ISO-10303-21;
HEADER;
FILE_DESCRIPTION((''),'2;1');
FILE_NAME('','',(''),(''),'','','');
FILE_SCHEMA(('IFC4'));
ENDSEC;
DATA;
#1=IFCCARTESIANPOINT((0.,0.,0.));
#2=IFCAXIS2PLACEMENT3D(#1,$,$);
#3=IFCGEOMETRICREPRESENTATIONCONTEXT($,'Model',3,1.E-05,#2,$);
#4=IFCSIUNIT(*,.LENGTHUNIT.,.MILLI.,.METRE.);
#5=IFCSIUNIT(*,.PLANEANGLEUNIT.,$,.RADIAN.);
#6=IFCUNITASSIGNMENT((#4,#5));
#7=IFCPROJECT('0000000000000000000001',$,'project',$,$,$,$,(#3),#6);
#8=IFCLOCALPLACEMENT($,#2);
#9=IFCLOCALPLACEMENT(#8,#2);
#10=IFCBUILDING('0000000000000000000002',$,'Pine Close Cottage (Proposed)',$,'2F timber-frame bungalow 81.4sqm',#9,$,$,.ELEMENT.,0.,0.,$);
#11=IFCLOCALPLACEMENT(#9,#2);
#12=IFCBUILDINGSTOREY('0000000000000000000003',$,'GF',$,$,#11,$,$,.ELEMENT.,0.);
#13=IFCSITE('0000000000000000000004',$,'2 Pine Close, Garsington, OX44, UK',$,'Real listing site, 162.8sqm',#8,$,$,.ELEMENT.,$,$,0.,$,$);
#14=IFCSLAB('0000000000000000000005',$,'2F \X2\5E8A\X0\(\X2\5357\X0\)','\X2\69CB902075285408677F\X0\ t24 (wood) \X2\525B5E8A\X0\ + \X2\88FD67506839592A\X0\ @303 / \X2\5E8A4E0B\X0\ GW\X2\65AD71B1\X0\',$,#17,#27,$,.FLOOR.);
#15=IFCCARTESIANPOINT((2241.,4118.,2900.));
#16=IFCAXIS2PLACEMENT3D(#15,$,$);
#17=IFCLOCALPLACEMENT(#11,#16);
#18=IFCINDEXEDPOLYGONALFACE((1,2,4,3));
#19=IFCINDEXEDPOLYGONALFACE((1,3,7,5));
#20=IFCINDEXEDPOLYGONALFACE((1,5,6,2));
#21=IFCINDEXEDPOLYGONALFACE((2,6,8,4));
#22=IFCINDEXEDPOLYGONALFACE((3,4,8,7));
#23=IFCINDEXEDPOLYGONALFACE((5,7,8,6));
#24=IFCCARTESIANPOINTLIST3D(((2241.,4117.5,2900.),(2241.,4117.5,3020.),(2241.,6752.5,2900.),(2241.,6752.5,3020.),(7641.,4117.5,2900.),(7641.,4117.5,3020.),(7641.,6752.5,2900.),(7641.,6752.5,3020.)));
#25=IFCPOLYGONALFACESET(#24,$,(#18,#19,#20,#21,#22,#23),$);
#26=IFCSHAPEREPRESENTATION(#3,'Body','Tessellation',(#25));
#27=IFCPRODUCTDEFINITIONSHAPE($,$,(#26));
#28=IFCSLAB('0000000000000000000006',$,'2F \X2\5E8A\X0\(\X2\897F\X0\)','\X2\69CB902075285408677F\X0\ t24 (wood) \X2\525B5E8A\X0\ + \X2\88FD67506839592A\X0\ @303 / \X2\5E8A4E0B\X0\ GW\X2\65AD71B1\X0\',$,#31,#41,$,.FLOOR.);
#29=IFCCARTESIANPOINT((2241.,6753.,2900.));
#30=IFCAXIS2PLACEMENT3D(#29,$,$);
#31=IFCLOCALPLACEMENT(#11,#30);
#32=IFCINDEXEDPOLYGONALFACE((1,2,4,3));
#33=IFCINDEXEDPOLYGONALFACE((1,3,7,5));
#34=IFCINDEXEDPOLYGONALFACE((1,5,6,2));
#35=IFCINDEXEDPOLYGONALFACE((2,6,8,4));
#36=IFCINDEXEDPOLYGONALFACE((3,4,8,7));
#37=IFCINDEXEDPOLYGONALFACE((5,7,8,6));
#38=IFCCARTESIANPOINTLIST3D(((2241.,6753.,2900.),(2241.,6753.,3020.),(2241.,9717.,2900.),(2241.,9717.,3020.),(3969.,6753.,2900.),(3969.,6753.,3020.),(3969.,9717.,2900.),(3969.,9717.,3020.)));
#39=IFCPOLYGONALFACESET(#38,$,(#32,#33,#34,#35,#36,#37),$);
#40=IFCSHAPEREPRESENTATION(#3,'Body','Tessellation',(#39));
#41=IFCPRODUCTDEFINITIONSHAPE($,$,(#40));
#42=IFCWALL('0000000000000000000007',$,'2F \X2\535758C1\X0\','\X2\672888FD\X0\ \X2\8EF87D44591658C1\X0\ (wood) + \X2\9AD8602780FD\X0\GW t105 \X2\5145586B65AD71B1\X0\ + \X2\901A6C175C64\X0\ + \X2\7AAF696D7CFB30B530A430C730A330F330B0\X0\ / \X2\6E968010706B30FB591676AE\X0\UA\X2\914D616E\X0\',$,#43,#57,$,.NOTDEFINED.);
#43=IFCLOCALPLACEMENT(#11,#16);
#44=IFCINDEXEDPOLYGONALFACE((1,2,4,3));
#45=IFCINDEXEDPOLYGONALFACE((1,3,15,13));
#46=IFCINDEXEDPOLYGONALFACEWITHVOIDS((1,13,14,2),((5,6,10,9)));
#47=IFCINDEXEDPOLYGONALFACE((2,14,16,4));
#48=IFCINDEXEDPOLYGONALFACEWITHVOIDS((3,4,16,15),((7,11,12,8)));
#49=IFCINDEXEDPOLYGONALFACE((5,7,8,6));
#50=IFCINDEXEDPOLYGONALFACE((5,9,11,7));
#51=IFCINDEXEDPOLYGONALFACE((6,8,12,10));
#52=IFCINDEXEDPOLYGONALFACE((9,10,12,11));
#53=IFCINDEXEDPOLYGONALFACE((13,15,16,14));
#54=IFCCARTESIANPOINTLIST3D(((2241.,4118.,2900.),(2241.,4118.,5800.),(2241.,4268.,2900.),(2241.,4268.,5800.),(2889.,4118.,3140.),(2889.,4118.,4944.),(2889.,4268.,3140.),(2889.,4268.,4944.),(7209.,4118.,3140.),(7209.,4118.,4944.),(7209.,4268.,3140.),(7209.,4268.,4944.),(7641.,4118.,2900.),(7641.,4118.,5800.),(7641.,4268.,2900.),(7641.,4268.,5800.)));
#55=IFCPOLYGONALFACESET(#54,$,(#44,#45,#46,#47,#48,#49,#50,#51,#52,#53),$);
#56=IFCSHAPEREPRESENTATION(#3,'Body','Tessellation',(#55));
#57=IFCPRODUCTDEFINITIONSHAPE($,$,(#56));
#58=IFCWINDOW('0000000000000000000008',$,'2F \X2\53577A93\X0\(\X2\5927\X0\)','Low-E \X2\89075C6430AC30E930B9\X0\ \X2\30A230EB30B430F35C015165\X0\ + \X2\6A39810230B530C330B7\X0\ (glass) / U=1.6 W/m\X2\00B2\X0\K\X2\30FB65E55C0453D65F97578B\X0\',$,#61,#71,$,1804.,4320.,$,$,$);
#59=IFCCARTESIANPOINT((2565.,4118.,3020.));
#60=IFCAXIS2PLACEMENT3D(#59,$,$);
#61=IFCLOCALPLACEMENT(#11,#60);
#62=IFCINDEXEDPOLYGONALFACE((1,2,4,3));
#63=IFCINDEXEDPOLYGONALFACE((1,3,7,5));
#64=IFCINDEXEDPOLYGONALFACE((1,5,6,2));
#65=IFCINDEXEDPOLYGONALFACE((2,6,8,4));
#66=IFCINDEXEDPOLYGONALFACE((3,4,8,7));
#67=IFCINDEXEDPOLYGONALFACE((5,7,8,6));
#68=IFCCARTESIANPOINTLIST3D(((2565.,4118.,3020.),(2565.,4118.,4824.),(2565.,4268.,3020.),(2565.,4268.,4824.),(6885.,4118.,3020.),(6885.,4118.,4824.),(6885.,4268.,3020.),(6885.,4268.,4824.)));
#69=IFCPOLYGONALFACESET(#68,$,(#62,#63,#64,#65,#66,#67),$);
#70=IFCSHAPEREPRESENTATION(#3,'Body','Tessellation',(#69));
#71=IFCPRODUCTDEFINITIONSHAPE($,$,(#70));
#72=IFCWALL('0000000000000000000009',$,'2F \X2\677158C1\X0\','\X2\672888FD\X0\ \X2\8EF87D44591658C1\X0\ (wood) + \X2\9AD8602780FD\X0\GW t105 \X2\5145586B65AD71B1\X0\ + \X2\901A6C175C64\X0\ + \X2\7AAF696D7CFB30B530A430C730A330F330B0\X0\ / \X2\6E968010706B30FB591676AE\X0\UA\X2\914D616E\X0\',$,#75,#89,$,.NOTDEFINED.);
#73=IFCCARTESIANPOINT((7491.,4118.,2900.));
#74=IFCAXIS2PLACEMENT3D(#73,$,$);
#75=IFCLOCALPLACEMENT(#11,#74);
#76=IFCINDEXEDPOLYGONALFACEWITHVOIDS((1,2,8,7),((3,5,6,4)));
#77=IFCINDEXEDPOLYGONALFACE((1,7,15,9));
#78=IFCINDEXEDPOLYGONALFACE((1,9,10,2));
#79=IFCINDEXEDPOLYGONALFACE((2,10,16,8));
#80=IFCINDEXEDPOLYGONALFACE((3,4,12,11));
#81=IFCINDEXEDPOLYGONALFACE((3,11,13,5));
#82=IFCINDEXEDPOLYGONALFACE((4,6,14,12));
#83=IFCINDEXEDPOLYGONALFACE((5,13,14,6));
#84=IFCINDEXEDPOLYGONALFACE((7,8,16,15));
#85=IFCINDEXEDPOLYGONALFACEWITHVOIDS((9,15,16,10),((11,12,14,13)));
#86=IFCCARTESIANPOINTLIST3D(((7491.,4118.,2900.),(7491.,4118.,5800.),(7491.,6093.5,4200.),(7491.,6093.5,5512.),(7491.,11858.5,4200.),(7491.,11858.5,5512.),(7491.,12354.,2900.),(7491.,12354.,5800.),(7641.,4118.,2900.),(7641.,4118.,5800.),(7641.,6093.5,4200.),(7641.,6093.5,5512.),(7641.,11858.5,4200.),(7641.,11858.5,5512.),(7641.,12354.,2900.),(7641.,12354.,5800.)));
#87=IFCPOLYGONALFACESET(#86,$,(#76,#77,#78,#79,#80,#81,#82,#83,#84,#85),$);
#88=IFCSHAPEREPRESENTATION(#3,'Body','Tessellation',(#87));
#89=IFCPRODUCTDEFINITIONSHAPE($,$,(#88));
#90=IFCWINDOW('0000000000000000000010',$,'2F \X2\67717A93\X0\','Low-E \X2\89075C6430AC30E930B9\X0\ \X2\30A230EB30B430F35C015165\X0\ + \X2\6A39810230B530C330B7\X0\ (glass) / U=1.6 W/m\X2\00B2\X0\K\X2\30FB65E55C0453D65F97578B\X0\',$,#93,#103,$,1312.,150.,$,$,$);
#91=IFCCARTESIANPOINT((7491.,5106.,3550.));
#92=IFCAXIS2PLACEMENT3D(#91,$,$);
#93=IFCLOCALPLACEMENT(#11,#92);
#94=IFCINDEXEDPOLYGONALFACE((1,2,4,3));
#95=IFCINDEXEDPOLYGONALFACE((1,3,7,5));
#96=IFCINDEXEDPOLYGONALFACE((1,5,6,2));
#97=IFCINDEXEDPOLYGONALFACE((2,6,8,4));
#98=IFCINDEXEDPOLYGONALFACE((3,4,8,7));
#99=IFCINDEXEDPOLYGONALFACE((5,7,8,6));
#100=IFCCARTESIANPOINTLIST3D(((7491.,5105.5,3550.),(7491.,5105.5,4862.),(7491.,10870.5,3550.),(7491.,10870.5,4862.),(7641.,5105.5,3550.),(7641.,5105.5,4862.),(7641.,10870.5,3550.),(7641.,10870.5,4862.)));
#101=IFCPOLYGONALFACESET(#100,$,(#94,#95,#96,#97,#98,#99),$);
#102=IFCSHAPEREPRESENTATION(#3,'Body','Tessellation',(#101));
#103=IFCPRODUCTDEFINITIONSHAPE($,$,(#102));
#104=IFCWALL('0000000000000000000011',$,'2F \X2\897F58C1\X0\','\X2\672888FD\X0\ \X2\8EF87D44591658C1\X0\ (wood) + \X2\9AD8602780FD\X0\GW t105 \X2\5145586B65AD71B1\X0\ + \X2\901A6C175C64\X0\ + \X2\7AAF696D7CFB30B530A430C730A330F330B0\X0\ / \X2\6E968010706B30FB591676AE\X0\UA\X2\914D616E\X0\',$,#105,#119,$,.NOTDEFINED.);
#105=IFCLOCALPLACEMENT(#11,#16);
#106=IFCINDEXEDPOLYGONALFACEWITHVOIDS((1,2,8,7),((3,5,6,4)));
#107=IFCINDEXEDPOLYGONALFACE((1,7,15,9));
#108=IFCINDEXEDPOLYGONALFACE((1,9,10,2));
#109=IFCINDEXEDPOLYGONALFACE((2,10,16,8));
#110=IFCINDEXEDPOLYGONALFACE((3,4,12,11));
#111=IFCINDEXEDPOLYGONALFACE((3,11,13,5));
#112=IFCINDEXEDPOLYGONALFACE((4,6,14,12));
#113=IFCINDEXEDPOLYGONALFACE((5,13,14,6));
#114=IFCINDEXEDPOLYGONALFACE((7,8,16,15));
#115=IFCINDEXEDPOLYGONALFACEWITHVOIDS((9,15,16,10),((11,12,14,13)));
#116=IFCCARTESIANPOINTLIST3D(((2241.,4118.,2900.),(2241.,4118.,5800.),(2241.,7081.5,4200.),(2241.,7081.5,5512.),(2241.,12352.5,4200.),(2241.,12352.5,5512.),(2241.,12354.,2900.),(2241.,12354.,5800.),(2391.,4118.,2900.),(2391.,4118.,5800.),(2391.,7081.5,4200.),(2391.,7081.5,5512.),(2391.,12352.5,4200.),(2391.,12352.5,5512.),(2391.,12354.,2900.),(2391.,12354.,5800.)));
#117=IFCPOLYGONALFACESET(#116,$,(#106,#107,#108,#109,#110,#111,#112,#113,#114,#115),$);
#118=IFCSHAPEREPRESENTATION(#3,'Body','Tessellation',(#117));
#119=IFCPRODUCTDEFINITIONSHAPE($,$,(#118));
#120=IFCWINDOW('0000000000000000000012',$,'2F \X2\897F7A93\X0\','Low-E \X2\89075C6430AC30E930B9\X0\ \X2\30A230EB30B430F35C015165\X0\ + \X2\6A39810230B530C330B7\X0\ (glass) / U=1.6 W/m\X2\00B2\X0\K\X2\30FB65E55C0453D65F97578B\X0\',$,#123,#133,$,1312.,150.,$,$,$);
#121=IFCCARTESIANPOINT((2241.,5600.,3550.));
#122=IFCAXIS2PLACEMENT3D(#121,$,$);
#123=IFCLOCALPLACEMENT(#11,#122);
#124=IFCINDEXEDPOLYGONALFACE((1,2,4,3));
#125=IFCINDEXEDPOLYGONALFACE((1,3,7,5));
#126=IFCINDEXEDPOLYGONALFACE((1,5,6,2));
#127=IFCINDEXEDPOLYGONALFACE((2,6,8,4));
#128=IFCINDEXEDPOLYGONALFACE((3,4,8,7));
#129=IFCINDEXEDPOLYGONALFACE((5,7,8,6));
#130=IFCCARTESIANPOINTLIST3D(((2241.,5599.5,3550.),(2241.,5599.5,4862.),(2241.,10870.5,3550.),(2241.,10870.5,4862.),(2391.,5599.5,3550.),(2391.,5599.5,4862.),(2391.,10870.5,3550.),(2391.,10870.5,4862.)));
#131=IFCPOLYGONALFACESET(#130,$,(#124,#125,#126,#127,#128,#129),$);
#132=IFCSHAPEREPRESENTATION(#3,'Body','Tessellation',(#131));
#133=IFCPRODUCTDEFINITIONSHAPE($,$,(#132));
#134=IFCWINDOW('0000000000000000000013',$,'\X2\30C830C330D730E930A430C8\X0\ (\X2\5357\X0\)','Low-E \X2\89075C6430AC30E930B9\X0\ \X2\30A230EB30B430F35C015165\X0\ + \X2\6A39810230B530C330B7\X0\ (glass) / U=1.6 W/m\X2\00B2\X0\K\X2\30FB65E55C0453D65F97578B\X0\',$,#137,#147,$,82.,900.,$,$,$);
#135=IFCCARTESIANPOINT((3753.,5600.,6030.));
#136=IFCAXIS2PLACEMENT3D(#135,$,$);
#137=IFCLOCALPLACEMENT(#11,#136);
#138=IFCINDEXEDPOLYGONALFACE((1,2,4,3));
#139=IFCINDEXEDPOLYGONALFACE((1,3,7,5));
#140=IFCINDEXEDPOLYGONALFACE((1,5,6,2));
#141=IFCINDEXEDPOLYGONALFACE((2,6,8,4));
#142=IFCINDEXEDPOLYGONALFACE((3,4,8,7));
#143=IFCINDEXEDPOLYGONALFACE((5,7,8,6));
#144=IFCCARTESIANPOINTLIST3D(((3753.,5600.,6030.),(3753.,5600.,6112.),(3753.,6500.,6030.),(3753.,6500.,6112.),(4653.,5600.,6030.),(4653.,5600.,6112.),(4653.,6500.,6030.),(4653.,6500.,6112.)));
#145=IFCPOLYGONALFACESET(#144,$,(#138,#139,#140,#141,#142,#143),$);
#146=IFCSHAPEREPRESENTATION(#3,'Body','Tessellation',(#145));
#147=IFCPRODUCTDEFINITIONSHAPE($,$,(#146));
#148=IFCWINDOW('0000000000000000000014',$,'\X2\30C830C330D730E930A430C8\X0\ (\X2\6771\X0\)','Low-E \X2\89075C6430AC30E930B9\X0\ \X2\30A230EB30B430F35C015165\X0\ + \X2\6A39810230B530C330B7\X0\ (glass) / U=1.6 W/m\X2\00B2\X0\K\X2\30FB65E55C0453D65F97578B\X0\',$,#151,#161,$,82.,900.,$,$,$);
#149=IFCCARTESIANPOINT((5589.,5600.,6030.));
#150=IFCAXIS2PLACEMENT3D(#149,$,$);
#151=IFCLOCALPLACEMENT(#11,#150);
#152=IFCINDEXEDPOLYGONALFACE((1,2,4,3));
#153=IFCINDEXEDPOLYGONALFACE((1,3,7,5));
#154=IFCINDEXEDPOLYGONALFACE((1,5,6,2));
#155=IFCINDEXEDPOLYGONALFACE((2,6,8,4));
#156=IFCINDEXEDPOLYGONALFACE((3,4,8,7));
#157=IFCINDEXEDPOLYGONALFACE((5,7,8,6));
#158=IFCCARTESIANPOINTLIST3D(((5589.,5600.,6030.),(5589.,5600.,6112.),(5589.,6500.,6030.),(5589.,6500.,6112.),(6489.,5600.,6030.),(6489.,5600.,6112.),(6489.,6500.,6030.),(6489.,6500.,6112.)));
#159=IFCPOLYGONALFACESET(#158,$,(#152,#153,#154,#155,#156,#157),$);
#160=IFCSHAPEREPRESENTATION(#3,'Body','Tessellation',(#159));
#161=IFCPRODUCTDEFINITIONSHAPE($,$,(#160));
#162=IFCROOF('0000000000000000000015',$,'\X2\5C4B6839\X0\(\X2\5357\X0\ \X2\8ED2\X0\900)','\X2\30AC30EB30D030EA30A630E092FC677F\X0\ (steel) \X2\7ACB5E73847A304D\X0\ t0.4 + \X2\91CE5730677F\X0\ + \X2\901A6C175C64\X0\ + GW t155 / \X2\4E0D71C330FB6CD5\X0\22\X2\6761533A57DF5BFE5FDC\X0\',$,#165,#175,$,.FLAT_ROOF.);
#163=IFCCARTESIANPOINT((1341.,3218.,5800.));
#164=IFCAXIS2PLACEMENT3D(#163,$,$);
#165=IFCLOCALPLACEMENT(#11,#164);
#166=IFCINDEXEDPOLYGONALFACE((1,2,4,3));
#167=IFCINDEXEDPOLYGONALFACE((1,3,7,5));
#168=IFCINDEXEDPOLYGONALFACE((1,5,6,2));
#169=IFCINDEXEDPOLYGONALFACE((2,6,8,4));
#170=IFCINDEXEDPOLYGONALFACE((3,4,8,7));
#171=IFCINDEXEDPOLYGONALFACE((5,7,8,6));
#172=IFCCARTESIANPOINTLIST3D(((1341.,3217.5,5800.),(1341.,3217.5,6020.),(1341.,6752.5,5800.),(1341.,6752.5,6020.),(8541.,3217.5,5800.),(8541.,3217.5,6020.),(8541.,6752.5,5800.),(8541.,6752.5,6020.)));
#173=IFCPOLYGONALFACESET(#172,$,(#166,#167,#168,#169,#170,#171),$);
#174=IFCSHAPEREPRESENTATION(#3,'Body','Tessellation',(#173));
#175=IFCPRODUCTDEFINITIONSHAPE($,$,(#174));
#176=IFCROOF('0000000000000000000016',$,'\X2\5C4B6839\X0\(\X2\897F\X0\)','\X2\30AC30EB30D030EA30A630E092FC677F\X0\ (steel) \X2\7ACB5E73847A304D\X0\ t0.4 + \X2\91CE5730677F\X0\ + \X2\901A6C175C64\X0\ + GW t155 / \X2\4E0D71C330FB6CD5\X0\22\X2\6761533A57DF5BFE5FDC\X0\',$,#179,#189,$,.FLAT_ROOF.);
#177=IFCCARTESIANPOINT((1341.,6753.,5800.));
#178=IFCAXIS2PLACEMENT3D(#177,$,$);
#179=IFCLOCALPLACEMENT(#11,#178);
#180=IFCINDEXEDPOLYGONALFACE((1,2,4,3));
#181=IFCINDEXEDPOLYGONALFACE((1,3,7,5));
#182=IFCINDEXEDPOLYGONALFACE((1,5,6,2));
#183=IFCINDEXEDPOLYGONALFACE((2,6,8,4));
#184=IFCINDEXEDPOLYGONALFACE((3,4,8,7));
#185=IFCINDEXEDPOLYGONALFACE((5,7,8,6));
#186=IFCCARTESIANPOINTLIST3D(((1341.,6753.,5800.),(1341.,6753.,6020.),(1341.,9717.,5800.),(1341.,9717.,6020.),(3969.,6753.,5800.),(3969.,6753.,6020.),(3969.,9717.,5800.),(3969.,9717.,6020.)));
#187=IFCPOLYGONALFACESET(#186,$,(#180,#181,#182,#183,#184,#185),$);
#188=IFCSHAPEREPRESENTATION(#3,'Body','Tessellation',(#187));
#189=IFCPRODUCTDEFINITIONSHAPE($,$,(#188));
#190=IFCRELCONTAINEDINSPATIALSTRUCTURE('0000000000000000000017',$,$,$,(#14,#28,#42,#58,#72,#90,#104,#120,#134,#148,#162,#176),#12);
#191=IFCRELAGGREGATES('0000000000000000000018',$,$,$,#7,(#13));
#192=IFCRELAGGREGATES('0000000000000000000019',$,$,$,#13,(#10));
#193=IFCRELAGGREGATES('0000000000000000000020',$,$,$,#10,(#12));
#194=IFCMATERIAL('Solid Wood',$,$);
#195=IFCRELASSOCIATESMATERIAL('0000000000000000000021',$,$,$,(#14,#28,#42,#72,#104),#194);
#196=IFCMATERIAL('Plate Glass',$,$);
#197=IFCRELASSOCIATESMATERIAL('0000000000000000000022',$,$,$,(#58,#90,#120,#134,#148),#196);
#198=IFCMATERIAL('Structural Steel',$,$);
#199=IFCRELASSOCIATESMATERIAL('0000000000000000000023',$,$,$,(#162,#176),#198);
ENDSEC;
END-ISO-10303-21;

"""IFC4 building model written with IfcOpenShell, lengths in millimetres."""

from ifc_helpers import new_model, si_unit, frame, frame_2d, origin, place, context, project, spatial, rectangle, extrude, material, element, fill, save


model = new_model("IFC4")

# Units and contexts
model_context = context("Model", 3, precision=1e-05, world=origin())
ifc_project = project(units=[si_unit("LENGTHUNIT", "METRE", prefix="MILLI"), si_unit("PLANEANGLEUNIT", "RADIAN")], contexts=[model_context])

# Site, building, storey
site_placement = place(None, origin())
site = spatial("IfcSite", under=ifc_project, at=site_placement, Name="2 Pine Close, Garsington, OX44, UK", ObjectType="Real listing site, 162.8sqm", CompositionType="ELEMENT", RefElevation=0.0)
building_placement = place(site_placement, origin())
building = spatial("IfcBuilding", under=site, at=building_placement, Name="Pine Close Cottage (Proposed)", ObjectType="2F timber-frame bungalow 81.4sqm", CompositionType="ELEMENT", ElevationOfRefHeight=0.0, ElevationOfTerrain=0.0)
storey_placement = place(building_placement, origin())
storey = spatial("IfcBuildingStorey", under=building, at=storey_placement, Name="GF", CompositionType="ELEMENT", Elevation=0.0)

# Slabs
ifc_material_1 = material(Name="Solid Wood")
slab_1_placement = place(storey_placement, frame((2241.0, 4118.0, 2900.0)))
element("IfcSlab", 1, at=slab_1_placement, inside=storey, material=ifc_material_1, Name="2F 床(南)", Description="構造用合板 t24 (wood) 剛床 + 製材根太 @303 / 床下 GW断熱", PredefinedType="FLOOR", context=model_context, shape_type="SweptSolid", body=[
    extrude(rectangle(XDim=5400.0, YDim=2635.0, at=frame_2d((2700.0, 1317.0))), frame((2241.0, 4118.0, 2900.0)), (0.0, 0.0, 1.0), 120.0),
])
slab_2_placement = place(storey_placement, frame((2241.0, 6753.0, 2900.0)))
element("IfcSlab", 2, at=slab_2_placement, inside=storey, material=ifc_material_1, Name="2F 床(西)", Description="構造用合板 t24 (wood) 剛床 + 製材根太 @303 / 床下 GW断熱", PredefinedType="FLOOR", context=model_context, shape_type="SweptSolid", body=[
    extrude(rectangle(XDim=1728.0, YDim=2964.0, at=frame_2d((864.0, 1482.0))), frame((2241.0, 6753.0, 2900.0)), (0.0, 0.0, 1.0), 120.0),
])

# Walls, openings, windows
wall_1_placement = place(storey_placement, frame((2241.0, 4118.0, 2900.0)))
wall_1 = element("IfcWall", 3, at=wall_1_placement, inside=storey, material=ifc_material_1, Name="2F 南壁", Description="木製 軸組外壁 (wood) + 高性能GW t105 充填断熱 + 通気層 + 窯業系サイディング / 準耐火・外皮UA配慮", PredefinedType="NOTDEFINED", context=model_context, shape_type="SweptSolid", body=[
    extrude(rectangle(XDim=5400.0, YDim=150.0, at=frame_2d((2700.0, 75.0))), frame((2241.0, 4118.0, 2900.0)), (0.0, 0.0, 1.0), 2900.0),
])
opening_1_placement = place(storey_placement, frame((2565.0, 4118.0, 3020.0)))
opening_1 = element("IfcOpeningElement", 4, at=opening_1_placement, cuts=wall_1, PredefinedType="NOTDEFINED", context=model_context, shape_type="SweptSolid", body=[
    extrude(rectangle(XDim=4320.0, YDim=150.0, at=frame_2d((2160.0, 75.0))), frame((2565.0, 4118.0, 3020.0)), (0.0, 0.0, 1.0), 1804.0),
])
ifc_material_2 = material(Name="Plate Glass")
window_1_placement = place(storey_placement, frame((2565.0, 4118.0, 3020.0)))
window_1 = element("IfcWindow", 5, at=window_1_placement, inside=storey, material=ifc_material_2, Name="2F 南窓(大)", Description="Low-E 複層ガラス アルゴン封入 + 樹脂サッシ (glass) / U=1.6 W/m²K・日射取得型", OverallHeight=1804.0, OverallWidth=4320.0, context=model_context, shape_type="SweptSolid", body=[
    extrude(rectangle(XDim=4320.0, YDim=150.0, at=frame_2d((2160.0, 75.0))), frame((2565.0, 4118.0, 3020.0)), (0.0, 0.0, 1.0), 1804.0),
])
fill(opening_1, window_1)
wall_2_placement = place(storey_placement, frame((7491.0, 4118.0, 2900.0)))
wall_2 = element("IfcWall", 6, at=wall_2_placement, inside=storey, material=ifc_material_1, Name="2F 東壁", Description="木製 軸組外壁 (wood) + 高性能GW t105 充填断熱 + 通気層 + 窯業系サイディング / 準耐火・外皮UA配慮", PredefinedType="NOTDEFINED", context=model_context, shape_type="SweptSolid", body=[
    extrude(rectangle(XDim=150.0, YDim=8236.0, at=frame_2d((75.0, 4118.0))), frame((7491.0, 4118.0, 2900.0)), (0.0, 0.0, 1.0), 2900.0),
])
opening_2_placement = place(storey_placement, frame((7491.0, 5106.0, 3550.0)))
opening_2 = element("IfcOpeningElement", 7, at=opening_2_placement, cuts=wall_2, PredefinedType="NOTDEFINED", context=model_context, shape_type="SweptSolid", body=[
    extrude(rectangle(XDim=150.0, YDim=5765.0, at=frame_2d((75.0, 2882.0))), frame((7491.0, 5106.0, 3550.0)), (0.0, 0.0, 1.0), 1312.0),
])
window_2_placement = place(storey_placement, frame((7491.0, 5106.0, 3550.0)))
window_2 = element("IfcWindow", 8, at=window_2_placement, inside=storey, material=ifc_material_2, Name="2F 東窓", Description="Low-E 複層ガラス アルゴン封入 + 樹脂サッシ (glass) / U=1.6 W/m²K・日射取得型", OverallHeight=1312.0, OverallWidth=150.0, context=model_context, shape_type="SweptSolid", body=[
    extrude(rectangle(XDim=150.0, YDim=5765.0, at=frame_2d((75.0, 2882.0))), frame((7491.0, 5106.0, 3550.0)), (0.0, 0.0, 1.0), 1312.0),
])
fill(opening_2, window_2)
wall_3_placement = place(storey_placement, frame((2241.0, 4118.0, 2900.0)))
wall_3 = element("IfcWall", 9, at=wall_3_placement, inside=storey, material=ifc_material_1, Name="2F 西壁", Description="木製 軸組外壁 (wood) + 高性能GW t105 充填断熱 + 通気層 + 窯業系サイディング / 準耐火・外皮UA配慮", PredefinedType="NOTDEFINED", context=model_context, shape_type="SweptSolid", body=[
    extrude(rectangle(XDim=150.0, YDim=8236.0, at=frame_2d((75.0, 4118.0))), frame((2241.0, 4118.0, 2900.0)), (0.0, 0.0, 1.0), 2900.0),
])
opening_3_placement = place(storey_placement, frame((2241.0, 5600.0, 3550.0)))
opening_3 = element("IfcOpeningElement", 10, at=opening_3_placement, cuts=wall_3, PredefinedType="NOTDEFINED", context=model_context, shape_type="SweptSolid", body=[
    extrude(rectangle(XDim=150.0, YDim=5271.0, at=frame_2d((75.0, 2635.0))), frame((2241.0, 5600.0, 3550.0)), (0.0, 0.0, 1.0), 1312.0),
])
window_3_placement = place(storey_placement, frame((2241.0, 5600.0, 3550.0)))
window_3 = element("IfcWindow", 11, at=window_3_placement, inside=storey, material=ifc_material_2, Name="2F 西窓", Description="Low-E 複層ガラス アルゴン封入 + 樹脂サッシ (glass) / U=1.6 W/m²K・日射取得型", OverallHeight=1312.0, OverallWidth=150.0, context=model_context, shape_type="SweptSolid", body=[
    extrude(rectangle(XDim=150.0, YDim=5271.0, at=frame_2d((75.0, 2635.0))), frame((2241.0, 5600.0, 3550.0)), (0.0, 0.0, 1.0), 1312.0),
])
fill(opening_3, window_3)

# Windows
window_4_placement = place(storey_placement, frame((3753.0, 5600.0, 6030.0)))
element("IfcWindow", 12, at=window_4_placement, inside=storey, material=ifc_material_2, Name="トップライト (南)", Description="Low-E 複層ガラス アルゴン封入 + 樹脂サッシ (glass) / U=1.6 W/m²K・日射取得型", OverallHeight=82.0, OverallWidth=900.0, context=model_context, shape_type="SweptSolid", body=[
    extrude(rectangle(XDim=900.0, YDim=900.0, at=frame_2d((450.0, 450.0))), frame((3753.0, 5600.0, 6030.0)), (0.0, 0.0, 1.0), 82.0),
])
window_5_placement = place(storey_placement, frame((5589.0, 5600.0, 6030.0)))
element("IfcWindow", 13, at=window_5_placement, inside=storey, material=ifc_material_2, Name="トップライト (東)", Description="Low-E 複層ガラス アルゴン封入 + 樹脂サッシ (glass) / U=1.6 W/m²K・日射取得型", OverallHeight=82.0, OverallWidth=900.0, context=model_context, shape_type="SweptSolid", body=[
    extrude(rectangle(XDim=900.0, YDim=900.0, at=frame_2d((450.0, 450.0))), frame((5589.0, 5600.0, 6030.0)), (0.0, 0.0, 1.0), 82.0),
])

# Roofs
ifc_material_3 = material(Name="Structural Steel")
roof_1_placement = place(storey_placement, frame((1341.0, 3218.0, 5800.0)))
element("IfcRoof", 14, at=roof_1_placement, inside=storey, material=ifc_material_3, Name="屋根(南 軒900)", Description="ガルバリウム鋼板 (steel) 立平葺き t0.4 + 野地板 + 通気層 + GW t155 / 不燃・法22条区域対応", PredefinedType="FLAT_ROOF", context=model_context, shape_type="SweptSolid", body=[
    extrude(rectangle(XDim=7200.0, YDim=3535.0, at=frame_2d((3600.0, 1767.0))), frame((1341.0, 3218.0, 5800.0)), (0.0, 0.0, 1.0), 220.0),
])
roof_2_placement = place(storey_placement, frame((1341.0, 6753.0, 5800.0)))
element("IfcRoof", 15, at=roof_2_placement, inside=storey, material=ifc_material_3, Name="屋根(西)", Description="ガルバリウム鋼板 (steel) 立平葺き t0.4 + 野地板 + 通気層 + GW t155 / 不燃・法22条区域対応", PredefinedType="FLAT_ROOF", context=model_context, shape_type="SweptSolid", body=[
    extrude(rectangle(XDim=2628.0, YDim=2964.0, at=frame_2d((1314.0, 1482.0))), frame((1341.0, 6753.0, 5800.0)), (0.0, 0.0, 1.0), 220.0),
])

save(model, "model.ifc")
